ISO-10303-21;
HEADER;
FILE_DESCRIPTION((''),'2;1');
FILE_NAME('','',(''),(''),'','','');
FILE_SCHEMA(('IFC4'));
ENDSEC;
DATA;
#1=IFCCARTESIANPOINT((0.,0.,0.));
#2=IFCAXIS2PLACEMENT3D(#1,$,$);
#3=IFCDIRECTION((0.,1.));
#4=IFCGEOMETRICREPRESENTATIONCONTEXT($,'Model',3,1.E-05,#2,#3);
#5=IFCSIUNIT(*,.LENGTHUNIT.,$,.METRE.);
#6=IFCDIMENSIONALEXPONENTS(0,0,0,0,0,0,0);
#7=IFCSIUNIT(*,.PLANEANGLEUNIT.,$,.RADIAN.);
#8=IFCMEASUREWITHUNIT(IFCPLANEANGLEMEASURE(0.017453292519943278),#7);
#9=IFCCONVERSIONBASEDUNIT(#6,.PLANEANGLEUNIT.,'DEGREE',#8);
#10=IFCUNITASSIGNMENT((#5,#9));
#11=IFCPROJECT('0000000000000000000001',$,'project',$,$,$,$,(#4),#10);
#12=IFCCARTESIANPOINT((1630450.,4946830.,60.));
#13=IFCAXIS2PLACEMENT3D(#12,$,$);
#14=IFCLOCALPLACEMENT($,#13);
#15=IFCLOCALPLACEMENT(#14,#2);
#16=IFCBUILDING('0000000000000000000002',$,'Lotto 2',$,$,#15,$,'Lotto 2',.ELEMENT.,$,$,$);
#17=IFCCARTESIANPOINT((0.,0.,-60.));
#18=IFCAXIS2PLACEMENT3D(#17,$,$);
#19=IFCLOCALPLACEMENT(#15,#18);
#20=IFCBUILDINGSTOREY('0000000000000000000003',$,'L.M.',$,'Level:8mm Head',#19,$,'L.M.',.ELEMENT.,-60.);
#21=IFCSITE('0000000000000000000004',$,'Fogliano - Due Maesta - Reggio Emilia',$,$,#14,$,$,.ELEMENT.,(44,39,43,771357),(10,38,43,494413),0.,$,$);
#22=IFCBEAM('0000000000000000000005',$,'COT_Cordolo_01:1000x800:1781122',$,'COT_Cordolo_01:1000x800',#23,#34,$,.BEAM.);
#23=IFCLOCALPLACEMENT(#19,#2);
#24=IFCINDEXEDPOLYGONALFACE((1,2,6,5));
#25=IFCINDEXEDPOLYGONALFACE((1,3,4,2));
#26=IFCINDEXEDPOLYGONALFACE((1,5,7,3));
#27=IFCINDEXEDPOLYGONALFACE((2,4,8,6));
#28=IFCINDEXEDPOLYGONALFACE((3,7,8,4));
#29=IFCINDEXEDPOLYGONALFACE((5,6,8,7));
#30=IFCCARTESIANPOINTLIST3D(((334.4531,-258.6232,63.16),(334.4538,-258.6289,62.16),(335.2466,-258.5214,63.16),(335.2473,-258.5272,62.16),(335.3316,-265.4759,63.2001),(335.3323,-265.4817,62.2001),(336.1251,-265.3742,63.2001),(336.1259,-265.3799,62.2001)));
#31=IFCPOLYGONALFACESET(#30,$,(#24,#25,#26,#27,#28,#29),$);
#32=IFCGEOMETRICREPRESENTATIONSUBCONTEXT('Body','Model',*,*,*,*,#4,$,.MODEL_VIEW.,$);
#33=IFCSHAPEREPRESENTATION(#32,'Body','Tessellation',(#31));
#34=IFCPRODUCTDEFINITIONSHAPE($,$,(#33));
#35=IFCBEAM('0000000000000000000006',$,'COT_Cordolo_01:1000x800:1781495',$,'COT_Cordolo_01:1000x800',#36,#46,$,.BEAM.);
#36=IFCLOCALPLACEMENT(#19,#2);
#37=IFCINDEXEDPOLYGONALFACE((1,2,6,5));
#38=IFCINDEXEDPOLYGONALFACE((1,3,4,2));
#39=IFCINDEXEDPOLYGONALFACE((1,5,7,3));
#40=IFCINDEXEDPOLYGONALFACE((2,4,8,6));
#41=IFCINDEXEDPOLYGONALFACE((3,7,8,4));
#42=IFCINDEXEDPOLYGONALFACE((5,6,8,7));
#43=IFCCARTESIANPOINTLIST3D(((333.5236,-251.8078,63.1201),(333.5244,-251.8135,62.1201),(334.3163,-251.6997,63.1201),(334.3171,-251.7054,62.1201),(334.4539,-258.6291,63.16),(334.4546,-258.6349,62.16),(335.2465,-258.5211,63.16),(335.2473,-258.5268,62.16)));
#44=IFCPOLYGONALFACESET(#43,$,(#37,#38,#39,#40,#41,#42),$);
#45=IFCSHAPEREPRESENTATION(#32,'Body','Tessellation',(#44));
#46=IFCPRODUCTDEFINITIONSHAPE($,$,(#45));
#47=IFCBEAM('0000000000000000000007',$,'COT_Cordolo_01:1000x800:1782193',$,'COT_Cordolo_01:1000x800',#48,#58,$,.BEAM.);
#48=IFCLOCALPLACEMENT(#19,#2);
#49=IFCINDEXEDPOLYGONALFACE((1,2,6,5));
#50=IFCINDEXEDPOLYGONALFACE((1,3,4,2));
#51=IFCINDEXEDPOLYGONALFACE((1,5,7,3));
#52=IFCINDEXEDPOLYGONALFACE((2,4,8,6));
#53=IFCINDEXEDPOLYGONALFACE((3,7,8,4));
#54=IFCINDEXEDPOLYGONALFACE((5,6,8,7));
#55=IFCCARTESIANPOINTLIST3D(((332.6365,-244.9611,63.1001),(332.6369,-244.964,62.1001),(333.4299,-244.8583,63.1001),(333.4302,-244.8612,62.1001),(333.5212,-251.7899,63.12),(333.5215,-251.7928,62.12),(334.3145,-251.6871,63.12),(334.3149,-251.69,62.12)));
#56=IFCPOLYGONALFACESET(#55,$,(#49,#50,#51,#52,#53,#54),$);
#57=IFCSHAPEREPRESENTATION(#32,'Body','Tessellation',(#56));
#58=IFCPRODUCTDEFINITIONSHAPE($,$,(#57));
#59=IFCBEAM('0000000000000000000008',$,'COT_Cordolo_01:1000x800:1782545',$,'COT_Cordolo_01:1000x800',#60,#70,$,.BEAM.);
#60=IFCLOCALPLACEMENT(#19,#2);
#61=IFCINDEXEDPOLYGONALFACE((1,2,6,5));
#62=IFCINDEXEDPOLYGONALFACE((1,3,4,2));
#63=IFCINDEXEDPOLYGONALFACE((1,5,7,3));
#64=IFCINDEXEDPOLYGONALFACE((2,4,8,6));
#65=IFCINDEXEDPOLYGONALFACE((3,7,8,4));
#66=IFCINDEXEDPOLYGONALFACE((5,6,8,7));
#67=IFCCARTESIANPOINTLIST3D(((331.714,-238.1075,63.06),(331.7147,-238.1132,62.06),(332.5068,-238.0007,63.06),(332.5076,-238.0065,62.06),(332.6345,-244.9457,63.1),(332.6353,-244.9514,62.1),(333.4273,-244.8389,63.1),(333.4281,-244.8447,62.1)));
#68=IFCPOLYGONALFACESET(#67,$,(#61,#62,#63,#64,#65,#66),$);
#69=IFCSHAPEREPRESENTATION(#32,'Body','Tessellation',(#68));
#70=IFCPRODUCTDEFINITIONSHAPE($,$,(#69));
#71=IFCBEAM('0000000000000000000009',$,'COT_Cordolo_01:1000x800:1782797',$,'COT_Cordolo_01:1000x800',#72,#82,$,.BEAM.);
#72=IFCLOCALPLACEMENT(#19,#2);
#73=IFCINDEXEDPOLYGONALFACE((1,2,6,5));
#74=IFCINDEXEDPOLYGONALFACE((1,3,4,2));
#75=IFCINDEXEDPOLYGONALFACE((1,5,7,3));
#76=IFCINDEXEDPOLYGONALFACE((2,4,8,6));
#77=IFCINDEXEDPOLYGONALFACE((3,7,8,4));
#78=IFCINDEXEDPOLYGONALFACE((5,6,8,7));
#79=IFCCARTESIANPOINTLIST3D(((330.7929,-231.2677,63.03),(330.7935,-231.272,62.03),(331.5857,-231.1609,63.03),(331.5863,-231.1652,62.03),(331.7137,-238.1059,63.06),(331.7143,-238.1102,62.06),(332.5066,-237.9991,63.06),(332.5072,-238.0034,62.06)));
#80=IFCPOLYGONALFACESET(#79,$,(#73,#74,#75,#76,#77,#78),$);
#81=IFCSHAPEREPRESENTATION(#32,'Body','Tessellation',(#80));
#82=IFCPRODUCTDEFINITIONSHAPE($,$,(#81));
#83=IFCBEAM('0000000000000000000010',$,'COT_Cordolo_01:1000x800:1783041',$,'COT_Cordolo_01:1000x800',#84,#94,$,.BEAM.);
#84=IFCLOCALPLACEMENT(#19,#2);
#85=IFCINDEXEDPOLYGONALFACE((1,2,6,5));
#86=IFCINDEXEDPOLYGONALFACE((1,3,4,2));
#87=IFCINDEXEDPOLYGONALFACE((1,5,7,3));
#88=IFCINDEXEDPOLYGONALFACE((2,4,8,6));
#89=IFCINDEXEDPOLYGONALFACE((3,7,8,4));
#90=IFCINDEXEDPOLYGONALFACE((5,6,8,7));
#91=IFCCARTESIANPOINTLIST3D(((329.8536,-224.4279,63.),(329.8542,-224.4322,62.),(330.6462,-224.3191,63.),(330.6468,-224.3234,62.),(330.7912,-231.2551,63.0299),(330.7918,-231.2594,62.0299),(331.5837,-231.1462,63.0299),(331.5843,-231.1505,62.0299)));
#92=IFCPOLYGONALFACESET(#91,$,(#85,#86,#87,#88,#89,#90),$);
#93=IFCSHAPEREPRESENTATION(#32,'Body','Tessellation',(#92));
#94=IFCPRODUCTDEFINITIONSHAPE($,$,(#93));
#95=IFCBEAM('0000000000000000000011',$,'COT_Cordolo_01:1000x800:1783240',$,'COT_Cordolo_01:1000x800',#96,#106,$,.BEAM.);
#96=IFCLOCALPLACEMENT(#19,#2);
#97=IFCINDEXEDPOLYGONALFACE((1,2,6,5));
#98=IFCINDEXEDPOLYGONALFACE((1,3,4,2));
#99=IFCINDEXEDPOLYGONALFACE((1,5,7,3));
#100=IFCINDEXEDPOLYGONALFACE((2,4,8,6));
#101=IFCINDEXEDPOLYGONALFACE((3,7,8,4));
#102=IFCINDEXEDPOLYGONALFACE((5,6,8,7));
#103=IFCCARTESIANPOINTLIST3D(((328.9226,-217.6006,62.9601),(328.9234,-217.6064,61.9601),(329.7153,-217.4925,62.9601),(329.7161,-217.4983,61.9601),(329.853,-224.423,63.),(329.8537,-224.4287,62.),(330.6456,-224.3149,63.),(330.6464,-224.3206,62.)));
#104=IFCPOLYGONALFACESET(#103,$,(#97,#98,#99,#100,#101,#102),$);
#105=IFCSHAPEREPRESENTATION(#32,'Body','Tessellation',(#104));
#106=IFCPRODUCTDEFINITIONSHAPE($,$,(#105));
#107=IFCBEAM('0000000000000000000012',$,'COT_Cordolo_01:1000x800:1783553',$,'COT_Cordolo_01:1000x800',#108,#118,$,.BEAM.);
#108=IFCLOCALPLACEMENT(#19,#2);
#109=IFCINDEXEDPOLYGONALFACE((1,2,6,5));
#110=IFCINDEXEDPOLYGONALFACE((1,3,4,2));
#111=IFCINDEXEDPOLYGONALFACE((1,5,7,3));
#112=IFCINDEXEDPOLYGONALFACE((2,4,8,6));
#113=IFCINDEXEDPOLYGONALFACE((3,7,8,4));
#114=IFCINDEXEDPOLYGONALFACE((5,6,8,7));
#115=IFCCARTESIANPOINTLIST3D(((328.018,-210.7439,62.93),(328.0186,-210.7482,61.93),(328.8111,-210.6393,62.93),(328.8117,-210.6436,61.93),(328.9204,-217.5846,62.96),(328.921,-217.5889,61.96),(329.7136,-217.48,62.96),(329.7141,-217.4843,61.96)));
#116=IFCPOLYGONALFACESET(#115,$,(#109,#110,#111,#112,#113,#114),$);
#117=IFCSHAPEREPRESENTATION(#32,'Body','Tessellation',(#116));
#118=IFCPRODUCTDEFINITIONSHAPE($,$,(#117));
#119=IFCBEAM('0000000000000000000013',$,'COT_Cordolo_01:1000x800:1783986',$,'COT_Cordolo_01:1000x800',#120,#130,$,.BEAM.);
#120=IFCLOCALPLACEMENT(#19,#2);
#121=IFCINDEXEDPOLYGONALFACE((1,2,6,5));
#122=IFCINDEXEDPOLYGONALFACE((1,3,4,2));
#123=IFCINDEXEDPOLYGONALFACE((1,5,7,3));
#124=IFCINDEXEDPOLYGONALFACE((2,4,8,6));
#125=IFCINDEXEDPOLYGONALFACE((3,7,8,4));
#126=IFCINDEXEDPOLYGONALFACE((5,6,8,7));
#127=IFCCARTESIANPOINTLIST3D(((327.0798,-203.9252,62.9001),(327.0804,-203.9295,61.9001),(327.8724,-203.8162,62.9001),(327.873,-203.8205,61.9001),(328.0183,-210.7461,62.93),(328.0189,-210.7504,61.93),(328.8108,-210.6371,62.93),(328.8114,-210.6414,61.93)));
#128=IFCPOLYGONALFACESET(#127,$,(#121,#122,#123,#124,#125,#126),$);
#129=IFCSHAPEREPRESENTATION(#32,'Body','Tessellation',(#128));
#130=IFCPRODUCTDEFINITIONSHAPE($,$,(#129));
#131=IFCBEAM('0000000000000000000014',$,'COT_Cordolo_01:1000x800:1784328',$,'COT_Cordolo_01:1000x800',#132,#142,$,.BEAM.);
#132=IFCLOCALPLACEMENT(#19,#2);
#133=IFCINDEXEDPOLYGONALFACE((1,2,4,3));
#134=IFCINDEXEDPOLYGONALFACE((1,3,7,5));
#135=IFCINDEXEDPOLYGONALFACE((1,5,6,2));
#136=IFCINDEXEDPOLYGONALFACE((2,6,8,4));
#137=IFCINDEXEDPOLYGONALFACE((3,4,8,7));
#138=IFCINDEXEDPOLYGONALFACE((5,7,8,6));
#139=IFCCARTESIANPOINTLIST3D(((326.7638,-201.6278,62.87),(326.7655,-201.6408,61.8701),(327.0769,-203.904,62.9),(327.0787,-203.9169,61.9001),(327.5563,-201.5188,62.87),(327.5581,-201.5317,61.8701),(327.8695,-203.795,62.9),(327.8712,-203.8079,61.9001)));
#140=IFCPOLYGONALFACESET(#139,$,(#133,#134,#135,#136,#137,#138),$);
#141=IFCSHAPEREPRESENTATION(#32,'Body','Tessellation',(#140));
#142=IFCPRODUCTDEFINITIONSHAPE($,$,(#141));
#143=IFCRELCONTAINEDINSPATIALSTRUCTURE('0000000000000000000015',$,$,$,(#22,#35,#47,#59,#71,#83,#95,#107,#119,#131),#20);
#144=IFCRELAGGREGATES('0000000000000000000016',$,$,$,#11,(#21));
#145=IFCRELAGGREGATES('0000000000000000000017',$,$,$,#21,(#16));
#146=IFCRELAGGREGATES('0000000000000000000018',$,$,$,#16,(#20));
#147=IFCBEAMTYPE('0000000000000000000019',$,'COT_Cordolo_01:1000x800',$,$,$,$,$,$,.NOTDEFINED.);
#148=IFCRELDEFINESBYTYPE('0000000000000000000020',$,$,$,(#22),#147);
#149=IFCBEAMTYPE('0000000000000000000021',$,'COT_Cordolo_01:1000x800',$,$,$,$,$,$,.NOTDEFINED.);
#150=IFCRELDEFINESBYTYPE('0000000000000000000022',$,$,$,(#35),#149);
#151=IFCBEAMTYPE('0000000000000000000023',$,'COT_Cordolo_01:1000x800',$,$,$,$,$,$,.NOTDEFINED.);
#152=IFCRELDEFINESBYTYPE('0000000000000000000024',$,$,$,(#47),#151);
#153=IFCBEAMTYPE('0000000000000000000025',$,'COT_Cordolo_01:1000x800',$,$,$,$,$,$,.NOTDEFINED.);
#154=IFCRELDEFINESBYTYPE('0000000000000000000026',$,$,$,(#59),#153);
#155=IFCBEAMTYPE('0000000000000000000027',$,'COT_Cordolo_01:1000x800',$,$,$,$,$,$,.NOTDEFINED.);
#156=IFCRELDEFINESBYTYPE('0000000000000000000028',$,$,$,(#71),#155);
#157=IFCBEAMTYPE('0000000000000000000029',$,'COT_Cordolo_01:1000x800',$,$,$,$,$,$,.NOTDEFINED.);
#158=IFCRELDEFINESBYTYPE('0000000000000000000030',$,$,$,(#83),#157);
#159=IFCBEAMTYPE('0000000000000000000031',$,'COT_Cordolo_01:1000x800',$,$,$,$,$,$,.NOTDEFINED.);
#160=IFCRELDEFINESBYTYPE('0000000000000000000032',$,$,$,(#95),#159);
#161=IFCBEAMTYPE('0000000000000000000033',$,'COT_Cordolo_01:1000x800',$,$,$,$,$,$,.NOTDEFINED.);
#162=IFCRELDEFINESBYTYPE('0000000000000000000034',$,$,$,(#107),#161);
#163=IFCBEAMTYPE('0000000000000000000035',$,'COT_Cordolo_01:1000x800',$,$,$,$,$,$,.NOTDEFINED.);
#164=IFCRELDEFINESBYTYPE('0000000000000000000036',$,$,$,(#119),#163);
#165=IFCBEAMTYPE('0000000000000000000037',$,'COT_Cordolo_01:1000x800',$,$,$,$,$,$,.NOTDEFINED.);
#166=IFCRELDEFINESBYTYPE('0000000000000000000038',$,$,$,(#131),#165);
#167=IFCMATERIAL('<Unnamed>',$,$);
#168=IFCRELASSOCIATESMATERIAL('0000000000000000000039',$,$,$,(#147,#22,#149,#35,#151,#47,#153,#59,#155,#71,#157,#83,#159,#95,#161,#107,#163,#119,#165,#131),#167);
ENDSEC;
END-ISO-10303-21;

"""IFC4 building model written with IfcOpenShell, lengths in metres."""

from ifc_helpers import new_model, entity, si_unit, converted_unit, direction, frame, origin, place, context, subcontext, project, spatial, indexed_curve, outline, extrude, source, transform, mapped, material, type_object, type_shapes, element, save


model = new_model("IFC4")

# Units and contexts
model_context = context("Model", 3, precision=1e-05, world=origin(), true_north=direction((0.0, 1.0)))
body_context = subcontext(model_context, "Body", "Model", "MODEL_VIEW")
ifc_project = project(units=[si_unit("LENGTHUNIT", "METRE"), converted_unit("PLANEANGLEUNIT", "DEGREE", entity("IfcPlaneAngleMeasure", 0.017453292519943278), si_unit("PLANEANGLEUNIT", "RADIAN"), dimensions=[0, 0, 0, 0, 0, 0, 0])], contexts=[model_context])

# Site, building, storey
site_placement = place(None, frame((1630450.0, 4946830.0, 60.0)))
site = spatial("IfcSite", under=ifc_project, at=site_placement, Name="Fogliano - Due Maesta - Reggio Emilia", CompositionType="ELEMENT", RefLatitude=(44, 39, 43, 771357), RefLongitude=(10, 38, 43, 494413), RefElevation=0.0)
building_placement = place(site_placement, origin())
building = spatial("IfcBuilding", under=site, at=building_placement, Name="Lotto 2", LongName="Lotto 2", CompositionType="ELEMENT")
storey_placement = place(building_placement, frame((0.0, 0.0, -60.0)))
storey = spatial("IfcBuildingStorey", under=building, at=storey_placement, Name="L.M.", ObjectType="Level:8mm Head", LongName="L.M.", CompositionType="ELEMENT", Elevation=-60.0)

# Beams
ifc_material_1 = material(Name="<Unnamed>")
beam_type_1 = type_object("IfcBeamType", Name="COT_Cordolo_01:1000x800", PredefinedType="NOTDEFINED", material=ifc_material_1)
shared_shape_1 = source(origin(), body_context, "Body", "SweptSolid", [
    extrude(outline(indexed_curve([(-3.4545, -0.4), (3.4545, -0.4), (3.4545, 0.4), (-3.4545, 0.4), (-3.4545, -0.4)], self_intersect=False)), frame((-0.0045, 0.0, -0.5), z_axis=(0.0, 0.0, 1.0), x_axis=(-1.0, 0.0, 0.0)), (0.0, 0.0, 1.0), 1.0),
])
type_shapes(beam_type_1, [shared_shape_1])
beam_1_placement = place(storey_placement, frame((335.2889, -261.9971, 62.68), z_axis=(-0.000737, 0.00575, 0.999983), x_axis=(-0.127162, 0.991865, -0.005797)))
element("IfcBeam", 1, at=beam_1_placement, inside=storey, type_object=beam_type_1, material=ifc_material_1, Name="COT_Cordolo_01:1000x800:1781122", ObjectType="COT_Cordolo_01:1000x800", PredefinedType="BEAM", context=body_context, shape_type="MappedRepresentation", body=[
    mapped(shared_shape_1, transform((0.0, 0.0, 0.0), scale=1.0)),
])
beam_type_2 = type_object("IfcBeamType", Name="COT_Cordolo_01:1000x800", PredefinedType="NOTDEFINED", material=ifc_material_1)
shared_shape_2 = source(origin(), body_context, "Body", "SweptSolid", [
    extrude(outline(indexed_curve([(-3.4423, -0.4), (3.4423, -0.4), (3.4423, 0.4), (-3.4423, 0.4), (-3.4423, -0.4)], self_intersect=False)), frame((-0.0077, 0.0, -0.5), z_axis=(0.0, 0.0, 1.0), x_axis=(-1.0, 0.0, 0.0)), (0.0, 0.0, 1.0), 1.0),
])
type_shapes(beam_type_2, [shared_shape_2])
beam_2_placement = place(storey_placement, frame((334.3844, -255.1597, 62.64), z_axis=(-0.000784, 0.005749, 0.999983), x_axis=(-0.13512, 0.990812, -0.005802)))
element("IfcBeam", 2, at=beam_2_placement, inside=storey, type_object=beam_type_2, material=ifc_material_1, Name="COT_Cordolo_01:1000x800:1781495", ObjectType="COT_Cordolo_01:1000x800", PredefinedType="BEAM", context=body_context, shape_type="MappedRepresentation", body=[
    mapped(shared_shape_2, transform((0.0, 0.0, 0.0), scale=1.0)),
])
beam_type_3 = type_object("IfcBeamType", Name="COT_Cordolo_01:1000x800", PredefinedType="NOTDEFINED", material=ifc_material_1)
shared_shape_3 = source(origin(), body_context, "Body", "SweptSolid", [
    extrude(outline(indexed_curve([(-3.4429, -0.4), (3.4429, -0.4), (3.4429, 0.4), (-3.4429, 0.4), (-3.4429, -0.4)], self_intersect=False)), frame((-0.0088, 0.0, -0.5), z_axis=(0.0, 0.0, 1.0), x_axis=(-1.0, 0.0, 0.0)), (0.0, 0.0, 1.0), 1.0),
])
type_shapes(beam_type_3, [shared_shape_3])
beam_3_placement = place(storey_placement, frame((333.4746, -248.3168, 62.61), z_axis=(-0.000372, 0.002871, 0.999996), x_axis=(-0.128477, 0.991708, -0.002895)))
element("IfcBeam", 3, at=beam_3_placement, inside=storey, type_object=beam_type_3, material=ifc_material_1, Name="COT_Cordolo_01:1000x800:1782193", ObjectType="COT_Cordolo_01:1000x800", PredefinedType="BEAM", context=body_context, shape_type="MappedRepresentation", body=[
    mapped(shared_shape_3, transform((0.0, 0.0, 0.0), scale=1.0)),
])
beam_type_4 = type_object("IfcBeamType", Name="COT_Cordolo_01:1000x800", PredefinedType="NOTDEFINED", material=ifc_material_1)
shared_shape_4 = source(origin(), body_context, "Body", "SweptSolid", [
    extrude(outline(indexed_curve([(-3.45, -0.4), (3.45, -0.4), (3.45, 0.4), (-3.45, 0.4), (-3.45, -0.4)], self_intersect=False)), frame((0.0, 0.0, -0.5), z_axis=(0.0, 0.0, 1.0), x_axis=(-1.0, 0.0, 0.0)), (0.0, 0.0, 1.0), 1.0),
])
type_shapes(beam_type_4, [shared_shape_4])
beam_4_placement = place(storey_placement, frame((332.571, -241.4761, 62.58), z_axis=(-0.000773, 0.005745, 0.999983), x_axis=(-0.133411, 0.991044, -0.005797)))
element("IfcBeam", 4, at=beam_4_placement, inside=storey, type_object=beam_type_4, material=ifc_material_1, Name="COT_Cordolo_01:1000x800:1782545", ObjectType="COT_Cordolo_01:1000x800", PredefinedType="BEAM", context=body_context, shape_type="MappedRepresentation", body=[
    mapped(shared_shape_4, transform((0.0, 0.0, 0.0), scale=1.0)),
])
beam_type_5 = type_object("IfcBeamType", Name="COT_Cordolo_01:1000x800", PredefinedType="NOTDEFINED", material=ifc_material_1)
shared_shape_5 = source(origin(), body_context, "Body", "SweptSolid", [
    extrude(outline(indexed_curve([(-3.45, -0.4), (3.45, -0.4), (3.45, 0.4), (-3.45, 0.4), (-3.45, -0.4)], self_intersect=False)), frame((0.0, 0.0, -0.5), z_axis=(0.0, 0.0, 1.0), x_axis=(-1.0, 0.0, 0.0)), (0.0, 0.0, 1.0), 1.0),
])
type_shapes(beam_type_5, [shared_shape_5])
beam_5_placement = place(storey_placement, frame((331.65, -234.6355, 62.545), z_axis=(-0.00058, 0.004309, 0.999991), x_axis=(-0.133458, 0.991045, -0.004348)))
element("IfcBeam", 5, at=beam_5_placement, inside=storey, type_object=beam_type_5, material=ifc_material_1, Name="COT_Cordolo_01:1000x800:1782797", ObjectType="COT_Cordolo_01:1000x800", PredefinedType="BEAM", context=body_context, shape_type="MappedRepresentation", body=[
    mapped(shared_shape_5, transform((0.0, 0.0, 0.0), scale=1.0)),
])
beam_type_6 = type_object("IfcBeamType", Name="COT_Cordolo_01:1000x800", PredefinedType="NOTDEFINED", material=ifc_material_1)
shared_shape_6 = source(origin(), body_context, "Body", "SweptSolid", [
    extrude(outline(indexed_curve([(-3.4456, -0.4), (3.4456, -0.4), (3.4456, 0.4), (-3.4456, 0.4), (-3.4456, -0.4)], self_intersect=False)), frame((0.0069, 0.0, -0.5), z_axis=(0.0, 0.0, 1.0), x_axis=(-1.0, 0.0, 0.0)), (0.0, 0.0, 1.0), 1.0),
])
type_shapes(beam_type_6, [shared_shape_6])
beam_6_placement = place(storey_placement, frame((330.7199, -227.796, 62.515), z_axis=(-0.000591, 0.004304, 0.999991), x_axis=(-0.136046, 0.990693, -0.004345)))
element("IfcBeam", 6, at=beam_6_placement, inside=storey, type_object=beam_type_6, material=ifc_material_1, Name="COT_Cordolo_01:1000x800:1783041", ObjectType="COT_Cordolo_01:1000x800", PredefinedType="BEAM", context=body_context, shape_type="MappedRepresentation", body=[
    mapped(shared_shape_6, transform((0.0, 0.0, 0.0), scale=1.0)),
])
beam_type_7 = type_object("IfcBeamType", Name="COT_Cordolo_01:1000x800", PredefinedType="NOTDEFINED", material=ifc_material_1)
shared_shape_7 = source(origin(), body_context, "Body", "SweptSolid", [
    extrude(outline(indexed_curve([(-3.4428, -0.4), (3.4428, -0.4), (3.4428, 0.4), (-3.4428, 0.4), (-3.4428, -0.4)], self_intersect=False)), frame((-0.0072, 0.0, -0.5), z_axis=(0.0, 0.0, 1.0), x_axis=(-1.0, 0.0, 0.0)), (0.0, 0.0, 1.0), 1.0),
])
type_shapes(beam_type_7, [shared_shape_7])
beam_7_placement = place(storey_placement, frame((329.7835, -220.9535, 62.48), z_axis=(-0.000783, 0.005744, 0.999983), x_axis=(-0.135111, 0.990814, -0.005797)))
element("IfcBeam", 7, at=beam_7_placement, inside=storey, type_object=beam_type_7, material=ifc_material_1, Name="COT_Cordolo_01:1000x800:1783240", ObjectType="COT_Cordolo_01:1000x800", PredefinedType="BEAM", context=body_context, shape_type="MappedRepresentation", body=[
    mapped(shared_shape_7, transform((0.0, 0.0, 0.0), scale=1.0)),
])
beam_type_8 = type_object("IfcBeamType", Name="COT_Cordolo_01:1000x800", PredefinedType="NOTDEFINED", material=ifc_material_1)
shared_shape_8 = source(origin(), body_context, "Body", "SweptSolid", [
    extrude(outline(indexed_curve([(-3.45, -0.4), (3.45, -0.4), (3.45, 0.4), (-3.45, 0.4), (-3.45, -0.4)], self_intersect=False)), frame((0.0, 0.0, -0.5), z_axis=(0.0, 0.0, 1.0), x_axis=(-1.0, 0.0, 0.0)), (0.0, 0.0, 1.0), 1.0),
])
type_shapes(beam_type_8, [shared_shape_8])
beam_8_placement = place(storey_placement, frame((328.8661, -214.1141, 62.445), z_axis=(-0.000569, 0.00431, 0.999991), x_axis=(-0.130788, 0.991401, -0.004348)))
element("IfcBeam", 8, at=beam_8_placement, inside=storey, type_object=beam_type_8, material=ifc_material_1, Name="COT_Cordolo_01:1000x800:1783553", ObjectType="COT_Cordolo_01:1000x800", PredefinedType="BEAM", context=body_context, shape_type="MappedRepresentation", body=[
    mapped(shared_shape_8, transform((0.0, 0.0, 0.0), scale=1.0)),
])
beam_type_9 = type_object("IfcBeamType", Name="COT_Cordolo_01:1000x800", PredefinedType="NOTDEFINED", material=ifc_material_1)
shared_shape_9 = source(origin(), body_context, "Body", "SweptSolid", [
    extrude(outline(indexed_curve([(-3.4426, -0.4), (3.4426, -0.4), (3.4426, 0.4), (-3.4426, 0.4), (-3.4426, -0.4)], self_intersect=False)), frame((-0.0074, 0.0, -0.5), z_axis=(0.0, 0.0, 1.0), x_axis=(-1.0, 0.0, 0.0)), (0.0, 0.0, 1.0), 1.0),
])
type_shapes(beam_type_9, [shared_shape_9])
beam_9_placement = place(storey_placement, frame((327.9446, -207.276, 62.415), z_axis=(-0.000593, 0.004307, 0.999991), x_axis=(-0.136301, 0.990658, -0.004348)))
element("IfcBeam", 9, at=beam_9_placement, inside=storey, type_object=beam_type_9, material=ifc_material_1, Name="COT_Cordolo_01:1000x800:1783986", ObjectType="COT_Cordolo_01:1000x800", PredefinedType="BEAM", context=body_context, shape_type="MappedRepresentation", body=[
    mapped(shared_shape_9, transform((0.0, 0.0, 0.0), scale=1.0)),
])
beam_type_10 = type_object("IfcBeamType", Name="COT_Cordolo_01:1000x800", PredefinedType="NOTDEFINED", material=ifc_material_1)
shared_shape_10 = source(origin(), body_context, "Body", "SweptSolid", [
    extrude(outline(indexed_curve([(-1.1489, -0.4), (1.1489, -0.4), (1.1489, 0.4), (-1.1489, 0.4), (-1.1489, -0.4)], self_intersect=False)), frame((0.0, 0.0, -0.5), z_axis=(0.0, 0.0, 1.0), x_axis=(-1.0, 0.0, 0.0)), (0.0, 0.0, 1.0), 1.0),
])
type_shapes(beam_type_10, [shared_shape_10])
beam_10_placement = place(storey_placement, frame((327.3175, -202.7179, 62.385), z_axis=(-0.001778, 0.012922, 0.999915), x_axis=(-0.136291, 0.990583, -0.013043)))
element("IfcBeam", 10, at=beam_10_placement, inside=storey, type_object=beam_type_10, material=ifc_material_1, Name="COT_Cordolo_01:1000x800:1784328", ObjectType="COT_Cordolo_01:1000x800", PredefinedType="BEAM", context=body_context, shape_type="MappedRepresentation", body=[
    mapped(shared_shape_10, transform((0.0, 0.0, 0.0), scale=1.0)),
])

save(model, "model.ifc")
